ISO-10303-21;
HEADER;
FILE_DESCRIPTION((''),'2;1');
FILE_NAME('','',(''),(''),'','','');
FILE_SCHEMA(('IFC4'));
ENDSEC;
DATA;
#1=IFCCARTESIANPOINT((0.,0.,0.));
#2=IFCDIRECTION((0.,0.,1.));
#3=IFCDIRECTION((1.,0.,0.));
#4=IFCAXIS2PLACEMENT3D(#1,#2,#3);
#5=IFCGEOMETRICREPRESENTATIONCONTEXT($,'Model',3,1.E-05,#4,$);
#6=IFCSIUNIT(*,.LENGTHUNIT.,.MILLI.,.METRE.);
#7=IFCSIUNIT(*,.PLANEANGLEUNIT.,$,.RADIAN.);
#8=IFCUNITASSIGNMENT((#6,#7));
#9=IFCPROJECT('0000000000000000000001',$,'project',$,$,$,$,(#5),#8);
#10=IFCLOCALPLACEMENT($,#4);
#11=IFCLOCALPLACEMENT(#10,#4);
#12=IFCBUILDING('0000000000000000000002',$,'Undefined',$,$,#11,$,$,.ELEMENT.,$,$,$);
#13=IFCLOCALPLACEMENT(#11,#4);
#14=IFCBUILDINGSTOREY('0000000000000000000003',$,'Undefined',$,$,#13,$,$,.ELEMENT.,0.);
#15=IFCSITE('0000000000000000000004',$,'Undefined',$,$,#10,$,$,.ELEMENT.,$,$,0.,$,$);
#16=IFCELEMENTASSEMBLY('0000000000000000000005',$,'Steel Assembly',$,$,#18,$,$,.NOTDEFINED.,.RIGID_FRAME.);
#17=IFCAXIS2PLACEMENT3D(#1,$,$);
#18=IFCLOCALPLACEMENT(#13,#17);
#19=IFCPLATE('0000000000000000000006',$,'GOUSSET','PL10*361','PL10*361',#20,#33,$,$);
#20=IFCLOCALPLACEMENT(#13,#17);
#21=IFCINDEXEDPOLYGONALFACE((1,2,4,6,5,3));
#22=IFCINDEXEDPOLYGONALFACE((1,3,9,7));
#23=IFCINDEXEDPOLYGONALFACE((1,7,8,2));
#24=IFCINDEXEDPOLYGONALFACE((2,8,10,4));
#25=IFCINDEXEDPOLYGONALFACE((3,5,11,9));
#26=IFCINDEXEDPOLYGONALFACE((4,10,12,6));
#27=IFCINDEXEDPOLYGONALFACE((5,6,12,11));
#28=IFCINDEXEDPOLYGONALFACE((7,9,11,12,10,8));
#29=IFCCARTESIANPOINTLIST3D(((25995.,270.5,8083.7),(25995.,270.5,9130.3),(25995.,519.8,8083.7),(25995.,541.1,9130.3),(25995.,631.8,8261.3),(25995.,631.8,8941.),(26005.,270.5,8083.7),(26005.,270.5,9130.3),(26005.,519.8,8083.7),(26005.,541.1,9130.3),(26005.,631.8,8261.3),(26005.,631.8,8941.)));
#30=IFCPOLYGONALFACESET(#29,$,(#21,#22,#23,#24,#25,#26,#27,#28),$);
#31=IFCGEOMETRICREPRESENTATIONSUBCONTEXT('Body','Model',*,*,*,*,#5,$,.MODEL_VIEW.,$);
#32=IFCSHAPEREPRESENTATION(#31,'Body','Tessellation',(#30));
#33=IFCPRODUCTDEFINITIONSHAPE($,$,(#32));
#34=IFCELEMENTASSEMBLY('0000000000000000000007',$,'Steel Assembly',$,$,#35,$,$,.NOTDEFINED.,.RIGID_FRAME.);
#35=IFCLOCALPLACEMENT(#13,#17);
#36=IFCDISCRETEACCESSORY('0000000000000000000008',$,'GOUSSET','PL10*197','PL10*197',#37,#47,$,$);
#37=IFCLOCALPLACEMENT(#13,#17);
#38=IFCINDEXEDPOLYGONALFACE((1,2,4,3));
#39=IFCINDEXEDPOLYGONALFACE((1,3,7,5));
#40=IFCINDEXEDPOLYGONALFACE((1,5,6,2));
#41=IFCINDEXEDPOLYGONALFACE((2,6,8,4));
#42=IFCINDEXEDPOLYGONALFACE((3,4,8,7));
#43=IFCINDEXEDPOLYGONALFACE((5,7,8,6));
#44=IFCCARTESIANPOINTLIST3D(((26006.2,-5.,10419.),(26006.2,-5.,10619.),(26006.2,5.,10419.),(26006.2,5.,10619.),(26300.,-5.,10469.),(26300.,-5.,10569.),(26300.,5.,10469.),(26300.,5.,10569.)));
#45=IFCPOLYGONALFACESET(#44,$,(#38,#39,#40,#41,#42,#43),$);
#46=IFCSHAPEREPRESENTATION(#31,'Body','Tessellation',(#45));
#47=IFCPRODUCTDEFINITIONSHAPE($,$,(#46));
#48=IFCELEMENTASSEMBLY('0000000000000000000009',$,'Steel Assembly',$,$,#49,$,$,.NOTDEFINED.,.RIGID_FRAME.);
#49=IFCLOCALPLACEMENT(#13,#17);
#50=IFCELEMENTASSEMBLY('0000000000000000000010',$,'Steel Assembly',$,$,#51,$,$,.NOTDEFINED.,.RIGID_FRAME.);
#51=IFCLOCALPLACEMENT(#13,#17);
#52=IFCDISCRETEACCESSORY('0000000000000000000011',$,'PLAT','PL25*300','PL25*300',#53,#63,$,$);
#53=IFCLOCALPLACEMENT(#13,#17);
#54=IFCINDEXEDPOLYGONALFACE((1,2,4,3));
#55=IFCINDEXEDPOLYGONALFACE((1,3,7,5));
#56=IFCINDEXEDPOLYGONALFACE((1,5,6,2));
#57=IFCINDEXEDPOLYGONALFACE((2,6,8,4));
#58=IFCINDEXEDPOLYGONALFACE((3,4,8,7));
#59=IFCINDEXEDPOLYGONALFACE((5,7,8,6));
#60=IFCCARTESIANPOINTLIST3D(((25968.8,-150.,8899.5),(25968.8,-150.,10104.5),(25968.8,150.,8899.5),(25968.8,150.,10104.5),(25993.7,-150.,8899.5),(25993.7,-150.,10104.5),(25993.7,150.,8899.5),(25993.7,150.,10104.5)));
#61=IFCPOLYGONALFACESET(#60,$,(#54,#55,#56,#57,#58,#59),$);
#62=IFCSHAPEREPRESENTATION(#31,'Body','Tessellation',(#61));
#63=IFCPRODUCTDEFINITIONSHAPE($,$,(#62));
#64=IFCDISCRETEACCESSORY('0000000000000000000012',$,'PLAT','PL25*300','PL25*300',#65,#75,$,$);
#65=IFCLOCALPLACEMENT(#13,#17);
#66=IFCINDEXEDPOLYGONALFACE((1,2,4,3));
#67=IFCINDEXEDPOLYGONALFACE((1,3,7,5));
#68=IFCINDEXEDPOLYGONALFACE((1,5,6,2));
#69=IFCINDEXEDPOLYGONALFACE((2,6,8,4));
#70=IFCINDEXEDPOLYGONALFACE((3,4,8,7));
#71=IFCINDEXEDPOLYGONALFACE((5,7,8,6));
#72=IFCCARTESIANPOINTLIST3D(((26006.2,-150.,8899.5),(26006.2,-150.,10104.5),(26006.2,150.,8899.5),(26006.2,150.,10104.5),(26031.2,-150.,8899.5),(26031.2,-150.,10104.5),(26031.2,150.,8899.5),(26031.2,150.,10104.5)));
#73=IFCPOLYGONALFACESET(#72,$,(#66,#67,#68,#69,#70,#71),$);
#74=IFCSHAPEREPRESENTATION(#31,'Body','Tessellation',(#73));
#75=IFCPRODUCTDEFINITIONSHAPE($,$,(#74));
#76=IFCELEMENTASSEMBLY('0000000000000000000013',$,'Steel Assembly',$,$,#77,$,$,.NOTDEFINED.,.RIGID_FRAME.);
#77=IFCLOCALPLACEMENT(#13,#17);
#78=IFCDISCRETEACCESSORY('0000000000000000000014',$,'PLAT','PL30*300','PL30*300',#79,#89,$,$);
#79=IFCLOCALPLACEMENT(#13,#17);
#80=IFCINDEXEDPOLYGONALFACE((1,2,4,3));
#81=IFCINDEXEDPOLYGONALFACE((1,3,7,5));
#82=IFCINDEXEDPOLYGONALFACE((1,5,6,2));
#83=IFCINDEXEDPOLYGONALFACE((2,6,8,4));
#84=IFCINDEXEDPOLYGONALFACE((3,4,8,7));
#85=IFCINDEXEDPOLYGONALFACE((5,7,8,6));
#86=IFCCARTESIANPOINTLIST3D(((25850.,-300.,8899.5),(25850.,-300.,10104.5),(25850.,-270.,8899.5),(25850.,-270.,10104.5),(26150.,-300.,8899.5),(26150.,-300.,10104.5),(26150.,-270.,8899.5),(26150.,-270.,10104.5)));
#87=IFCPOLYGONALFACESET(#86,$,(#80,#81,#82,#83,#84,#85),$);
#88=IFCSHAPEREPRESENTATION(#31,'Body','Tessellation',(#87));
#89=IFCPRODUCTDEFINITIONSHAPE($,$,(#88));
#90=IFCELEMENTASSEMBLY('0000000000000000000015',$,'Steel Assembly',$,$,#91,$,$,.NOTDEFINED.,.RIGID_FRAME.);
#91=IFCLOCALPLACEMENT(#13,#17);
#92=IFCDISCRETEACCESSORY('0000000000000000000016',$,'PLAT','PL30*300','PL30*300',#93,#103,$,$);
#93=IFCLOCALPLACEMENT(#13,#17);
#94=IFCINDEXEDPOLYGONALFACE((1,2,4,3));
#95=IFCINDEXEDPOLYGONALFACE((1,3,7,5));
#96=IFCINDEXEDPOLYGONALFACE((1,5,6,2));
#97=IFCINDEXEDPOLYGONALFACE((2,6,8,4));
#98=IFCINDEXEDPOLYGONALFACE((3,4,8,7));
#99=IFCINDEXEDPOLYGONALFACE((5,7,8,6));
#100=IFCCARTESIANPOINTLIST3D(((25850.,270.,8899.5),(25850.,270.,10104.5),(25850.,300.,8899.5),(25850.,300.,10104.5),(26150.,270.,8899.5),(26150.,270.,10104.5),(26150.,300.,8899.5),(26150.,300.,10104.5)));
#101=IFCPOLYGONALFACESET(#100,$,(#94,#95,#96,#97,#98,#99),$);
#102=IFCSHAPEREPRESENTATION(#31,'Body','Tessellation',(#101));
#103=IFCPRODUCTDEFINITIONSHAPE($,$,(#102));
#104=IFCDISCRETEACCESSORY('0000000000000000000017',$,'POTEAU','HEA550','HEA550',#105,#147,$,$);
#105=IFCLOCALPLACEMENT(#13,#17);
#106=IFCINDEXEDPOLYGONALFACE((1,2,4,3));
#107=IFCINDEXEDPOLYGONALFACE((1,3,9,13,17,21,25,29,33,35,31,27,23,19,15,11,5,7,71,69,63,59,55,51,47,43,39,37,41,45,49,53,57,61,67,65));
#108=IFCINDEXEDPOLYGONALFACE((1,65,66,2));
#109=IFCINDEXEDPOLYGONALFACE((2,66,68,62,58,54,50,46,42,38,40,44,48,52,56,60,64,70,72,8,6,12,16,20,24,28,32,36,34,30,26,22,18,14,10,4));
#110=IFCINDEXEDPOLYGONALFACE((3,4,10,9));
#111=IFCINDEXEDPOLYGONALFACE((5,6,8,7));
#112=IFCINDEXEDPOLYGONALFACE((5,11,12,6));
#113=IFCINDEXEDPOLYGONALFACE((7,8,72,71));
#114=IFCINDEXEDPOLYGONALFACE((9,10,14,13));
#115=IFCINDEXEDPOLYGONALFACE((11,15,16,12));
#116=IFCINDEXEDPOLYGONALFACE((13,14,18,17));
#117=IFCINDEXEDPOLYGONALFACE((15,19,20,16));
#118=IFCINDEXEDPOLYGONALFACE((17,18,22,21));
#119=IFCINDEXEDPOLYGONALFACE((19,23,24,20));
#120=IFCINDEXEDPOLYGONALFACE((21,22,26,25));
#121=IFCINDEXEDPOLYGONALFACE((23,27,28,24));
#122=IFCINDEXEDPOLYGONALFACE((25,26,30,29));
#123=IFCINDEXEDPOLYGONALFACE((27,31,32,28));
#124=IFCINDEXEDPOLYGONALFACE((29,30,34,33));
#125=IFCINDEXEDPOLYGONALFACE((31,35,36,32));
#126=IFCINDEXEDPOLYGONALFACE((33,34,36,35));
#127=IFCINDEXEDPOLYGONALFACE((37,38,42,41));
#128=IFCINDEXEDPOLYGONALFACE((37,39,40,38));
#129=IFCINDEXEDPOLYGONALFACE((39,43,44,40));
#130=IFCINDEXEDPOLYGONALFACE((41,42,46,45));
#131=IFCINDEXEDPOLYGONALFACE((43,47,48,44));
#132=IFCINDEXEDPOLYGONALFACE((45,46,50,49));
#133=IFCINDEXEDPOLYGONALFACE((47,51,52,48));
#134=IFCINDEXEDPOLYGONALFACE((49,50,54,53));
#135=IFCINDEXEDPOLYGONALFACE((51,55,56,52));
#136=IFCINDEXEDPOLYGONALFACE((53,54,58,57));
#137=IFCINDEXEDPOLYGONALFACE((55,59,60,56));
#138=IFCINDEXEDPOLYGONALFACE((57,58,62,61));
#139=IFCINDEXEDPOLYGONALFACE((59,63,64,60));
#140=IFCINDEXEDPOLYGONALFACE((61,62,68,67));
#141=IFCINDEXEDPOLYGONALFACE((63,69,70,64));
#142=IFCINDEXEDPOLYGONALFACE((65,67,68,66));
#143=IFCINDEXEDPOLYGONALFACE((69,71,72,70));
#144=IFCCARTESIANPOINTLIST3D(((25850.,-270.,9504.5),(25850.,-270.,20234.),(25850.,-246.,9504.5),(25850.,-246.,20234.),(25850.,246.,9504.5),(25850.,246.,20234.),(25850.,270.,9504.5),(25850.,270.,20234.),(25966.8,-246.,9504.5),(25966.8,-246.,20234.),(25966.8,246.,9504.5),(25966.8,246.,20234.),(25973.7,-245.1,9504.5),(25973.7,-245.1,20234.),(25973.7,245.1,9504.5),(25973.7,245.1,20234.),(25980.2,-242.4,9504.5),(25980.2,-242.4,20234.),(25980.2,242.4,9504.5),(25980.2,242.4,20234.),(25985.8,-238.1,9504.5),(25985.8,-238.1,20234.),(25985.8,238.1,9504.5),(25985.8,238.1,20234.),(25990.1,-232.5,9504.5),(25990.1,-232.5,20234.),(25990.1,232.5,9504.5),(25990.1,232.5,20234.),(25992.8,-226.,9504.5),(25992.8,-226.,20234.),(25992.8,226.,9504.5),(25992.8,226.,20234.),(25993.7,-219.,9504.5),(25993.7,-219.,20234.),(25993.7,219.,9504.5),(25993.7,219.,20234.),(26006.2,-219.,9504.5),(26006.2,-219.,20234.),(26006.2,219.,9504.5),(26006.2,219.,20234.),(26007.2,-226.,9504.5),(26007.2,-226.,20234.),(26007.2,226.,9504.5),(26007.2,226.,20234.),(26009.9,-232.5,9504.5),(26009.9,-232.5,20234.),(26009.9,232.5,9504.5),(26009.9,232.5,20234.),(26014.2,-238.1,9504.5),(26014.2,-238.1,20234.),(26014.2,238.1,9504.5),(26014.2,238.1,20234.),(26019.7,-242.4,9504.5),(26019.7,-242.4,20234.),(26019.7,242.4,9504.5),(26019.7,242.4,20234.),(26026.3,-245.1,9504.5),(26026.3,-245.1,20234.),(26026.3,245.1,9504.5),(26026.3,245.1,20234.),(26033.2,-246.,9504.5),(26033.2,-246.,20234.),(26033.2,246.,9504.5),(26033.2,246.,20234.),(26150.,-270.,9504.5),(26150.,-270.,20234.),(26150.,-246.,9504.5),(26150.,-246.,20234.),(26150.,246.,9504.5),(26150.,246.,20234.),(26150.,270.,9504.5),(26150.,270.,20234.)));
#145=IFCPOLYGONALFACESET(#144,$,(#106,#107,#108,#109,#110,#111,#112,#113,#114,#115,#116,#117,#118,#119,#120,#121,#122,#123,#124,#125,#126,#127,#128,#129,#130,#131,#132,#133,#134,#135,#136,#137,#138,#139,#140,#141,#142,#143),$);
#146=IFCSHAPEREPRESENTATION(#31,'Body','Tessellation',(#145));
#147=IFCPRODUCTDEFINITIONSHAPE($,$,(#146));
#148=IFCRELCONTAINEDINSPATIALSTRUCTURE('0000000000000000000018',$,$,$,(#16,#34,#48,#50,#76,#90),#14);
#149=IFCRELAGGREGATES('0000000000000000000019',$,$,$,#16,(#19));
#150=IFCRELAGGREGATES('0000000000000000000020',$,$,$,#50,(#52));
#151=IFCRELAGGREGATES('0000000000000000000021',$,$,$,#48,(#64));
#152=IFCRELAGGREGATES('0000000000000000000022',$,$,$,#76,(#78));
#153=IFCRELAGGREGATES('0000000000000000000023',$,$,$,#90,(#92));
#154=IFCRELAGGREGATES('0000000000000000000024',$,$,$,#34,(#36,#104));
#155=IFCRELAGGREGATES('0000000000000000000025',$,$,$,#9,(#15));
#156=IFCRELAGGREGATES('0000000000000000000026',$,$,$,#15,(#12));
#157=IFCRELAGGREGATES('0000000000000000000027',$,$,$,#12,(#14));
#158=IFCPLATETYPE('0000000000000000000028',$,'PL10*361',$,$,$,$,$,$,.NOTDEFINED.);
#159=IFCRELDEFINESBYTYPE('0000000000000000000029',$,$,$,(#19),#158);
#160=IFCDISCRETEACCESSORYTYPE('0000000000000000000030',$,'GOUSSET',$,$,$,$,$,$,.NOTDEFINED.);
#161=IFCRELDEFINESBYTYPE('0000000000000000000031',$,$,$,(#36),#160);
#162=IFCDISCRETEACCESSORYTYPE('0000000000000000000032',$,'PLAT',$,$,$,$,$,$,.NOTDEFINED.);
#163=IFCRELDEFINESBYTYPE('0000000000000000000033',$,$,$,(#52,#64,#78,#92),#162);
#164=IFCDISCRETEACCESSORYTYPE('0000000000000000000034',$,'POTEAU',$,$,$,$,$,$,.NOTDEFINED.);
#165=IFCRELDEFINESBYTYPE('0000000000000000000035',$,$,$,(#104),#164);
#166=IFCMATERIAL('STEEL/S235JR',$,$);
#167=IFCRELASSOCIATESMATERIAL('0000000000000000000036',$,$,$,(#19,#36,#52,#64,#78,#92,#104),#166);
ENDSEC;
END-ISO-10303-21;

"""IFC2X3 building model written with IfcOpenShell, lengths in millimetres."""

from ifc_helpers import new_model, si_unit, frame, origin_with_axes, origin_2d_with_axis, place, context, subcontext, project, spatial, polyline, i_section, outline, extrude, material, type_object, element, aggregate, save


model = new_model("IFC2X3")

# Units and contexts
model_context = context("Model", 3, precision=1e-05, world=origin_with_axes())
body_context = subcontext(model_context, "Body", "Model", "MODEL_VIEW")
ifc_project = project(units=[si_unit("LENGTHUNIT", "METRE", prefix="MILLI"), si_unit("PLANEANGLEUNIT", "RADIAN")], contexts=[model_context])

# Site, building, storey
site_placement = place(None, origin_with_axes())
site = spatial("IfcSite", under=ifc_project, at=site_placement, Name="Undefined", CompositionType="ELEMENT", RefElevation=0.0)
building_placement = place(site_placement, origin_with_axes())
building = spatial("IfcBuilding", under=site, at=building_placement, Name="Undefined", CompositionType="ELEMENT")
storey_placement = place(building_placement, origin_with_axes())
storey = spatial("IfcBuildingStorey", under=building, at=storey_placement, Name="Undefined", CompositionType="ELEMENT", Elevation=0.0)

# Shared definitions
ifc_material_1 = material(Name="STEEL/S235JR")

# Element assembly, plate
plate_type = type_object("IfcPlateType", Name="PL10*361", PredefinedType="NOTDEFINED")
assembly_1_placement = place(storey_placement, origin_with_axes())
assembly_1 = element("IfcElementAssembly", 1, at=assembly_1_placement, inside=storey, Name="Steel Assembly", AssemblyPlace="NOTDEFINED", PredefinedType="RIGID_FRAME")
plate_1_placement = place(assembly_1_placement, frame((26000.0, 541.1, 9130.3), z_axis=(1.0, 0.0, 0.0), x_axis=(0.0, -1.0, 0.0)))
plate_1 = element("IfcPlate", 2, at=plate_1_placement, type_object=plate_type, material=ifc_material_1, Name="GOUSSET", Description="PL10*361", ObjectType="PL10*361", context=body_context, shape_type="SweptSolid", body=[
    extrude(outline(polyline([(0.0, 0.0), (270.5, 0.0), (270.5, 1046.7), (21.3, 1046.7), (-90.7, 869.1), (-90.7, 189.4), (0.0, 0.0)])), frame((0.0, 0.0, -5.0), z_axis=(0.0, 0.0, 1.0), x_axis=(1.0, 0.0, 0.0)), (0.0, 0.0, 1.0), 10.0),
])
aggregate(assembly_1, [plate_1])

# Element assembly, discrete accessory
assembly_2_placement = place(storey_placement, origin_with_axes())
assembly_2 = element("IfcElementAssembly", 3, at=assembly_2_placement, inside=storey, Name="Steel Assembly", AssemblyPlace="NOTDEFINED", PredefinedType="RIGID_FRAME")
discrete_accessory_type_1 = type_object("IfcDiscreteAccessoryType", Name="GOUSSET")
discrete_accessory_1_placement = place(assembly_2_placement, frame((26006.2, 0.0, 10619.0), z_axis=(0.0, -1.0, 0.0), x_axis=(0.0, 0.0, -1.0)))
discrete_accessory_1 = element("IfcDiscreteAccessory", 4, at=discrete_accessory_1_placement, type_object=discrete_accessory_type_1, material=ifc_material_1, Name="GOUSSET", Description="PL10*197", ObjectType="PL10*197", context=body_context, shape_type="SweptSolid", body=[
    extrude(outline(polyline([(0.0, 0.0), (200.0, 0.0), (150.0, 293.8), (50.0, 293.8), (0.0, 0.0)])), frame((0.0, 0.0, -5.0), z_axis=(0.0, 0.0, 1.0), x_axis=(1.0, 0.0, 0.0)), (0.0, 0.0, 1.0), 10.0),
])

# Element assembly
assembly_3_placement = place(storey_placement, origin_with_axes())
assembly_3 = element("IfcElementAssembly", 5, at=assembly_3_placement, inside=storey, Name="Steel Assembly", AssemblyPlace="NOTDEFINED", PredefinedType="RIGID_FRAME")

# Element assembly, discrete accessory
assembly_4_placement = place(storey_placement, origin_with_axes())
assembly_4 = element("IfcElementAssembly", 6, at=assembly_4_placement, inside=storey, Name="Steel Assembly", AssemblyPlace="NOTDEFINED", PredefinedType="RIGID_FRAME")
discrete_accessory_type_2 = type_object("IfcDiscreteAccessoryType", Name="PLAT")
discrete_accessory_2_placement = place(assembly_4_placement, frame((25981.2, 0.0, 10104.5), z_axis=(1.0, 0.0, 0.0), x_axis=(0.0, 0.0, -1.0)))
discrete_accessory_2 = element("IfcDiscreteAccessory", 7, at=discrete_accessory_2_placement, type_object=discrete_accessory_type_2, material=ifc_material_1, Name="PLAT", Description="PL25*300", ObjectType="PL25*300", context=body_context, shape_type="SweptSolid", body=[
    extrude(outline(polyline([(0.0, -150.0), (0.0, 150.0), (1205.0, 150.0), (1205.0, -150.0), (0.0, -150.0)])), frame((0.0, 0.0, -12.5), z_axis=(0.0, 0.0, 1.0), x_axis=(1.0, 0.0, 0.0)), (0.0, 0.0, 1.0), 25.0),
])
aggregate(assembly_4, [discrete_accessory_2])

# Discrete accessory
discrete_accessory_3_placement = place(assembly_3_placement, frame((26018.8, 0.0, 10104.5), z_axis=(1.0, 0.0, 0.0), x_axis=(0.0, 0.0, -1.0)))
discrete_accessory_3 = element("IfcDiscreteAccessory", 8, at=discrete_accessory_3_placement, type_object=discrete_accessory_type_2, material=ifc_material_1, Name="PLAT", Description="PL25*300", ObjectType="PL25*300", context=body_context, shape_type="SweptSolid", body=[
    extrude(outline(polyline([(0.0, -150.0), (0.0, 150.0), (1205.0, 150.0), (1205.0, -150.0), (0.0, -150.0)])), frame((0.0, 0.0, -12.5), z_axis=(0.0, 0.0, 1.0), x_axis=(1.0, 0.0, 0.0)), (0.0, 0.0, 1.0), 25.0),
])
aggregate(assembly_3, [discrete_accessory_3])

# Element assemblies, discrete accessories
assembly_5_placement = place(storey_placement, origin_with_axes())
assembly_5 = element("IfcElementAssembly", 9, at=assembly_5_placement, inside=storey, Name="Steel Assembly", AssemblyPlace="NOTDEFINED", PredefinedType="RIGID_FRAME")
discrete_accessory_4_placement = place(assembly_5_placement, frame((26000.0, -285.0, 10104.5), z_axis=(0.0, -1.0, 0.0), x_axis=(0.0, 0.0, -1.0)))
discrete_accessory_4 = element("IfcDiscreteAccessory", 10, at=discrete_accessory_4_placement, type_object=discrete_accessory_type_2, material=ifc_material_1, Name="PLAT", Description="PL30*300", ObjectType="PL30*300", context=body_context, shape_type="SweptSolid", body=[
    extrude(outline(polyline([(0.0, -150.0), (0.0, 150.0), (1205.0, 150.0), (1205.0, -150.0), (0.0, -150.0)])), frame((0.0, 0.0, -15.0), z_axis=(0.0, 0.0, 1.0), x_axis=(1.0, 0.0, 0.0)), (0.0, 0.0, 1.0), 30.0),
])
aggregate(assembly_5, [discrete_accessory_4])
assembly_6_placement = place(storey_placement, origin_with_axes())
assembly_6 = element("IfcElementAssembly", 11, at=assembly_6_placement, inside=storey, Name="Steel Assembly", AssemblyPlace="NOTDEFINED", PredefinedType="RIGID_FRAME")
discrete_accessory_5_placement = place(assembly_6_placement, frame((26000.0, 285.0, 10104.5), z_axis=(0.0, -1.0, 0.0), x_axis=(0.0, 0.0, -1.0)))
discrete_accessory_5 = element("IfcDiscreteAccessory", 12, at=discrete_accessory_5_placement, type_object=discrete_accessory_type_2, material=ifc_material_1, Name="PLAT", Description="PL30*300", ObjectType="PL30*300", context=body_context, shape_type="SweptSolid", body=[
    extrude(outline(polyline([(0.0, -150.0), (0.0, 150.0), (1205.0, 150.0), (1205.0, -150.0), (0.0, -150.0)])), frame((0.0, 0.0, -15.0), z_axis=(0.0, 0.0, 1.0), x_axis=(1.0, 0.0, 0.0)), (0.0, 0.0, 1.0), 30.0),
])
aggregate(assembly_6, [discrete_accessory_5])

# Discrete accessory
discrete_accessory_type_3 = type_object("IfcDiscreteAccessoryType", Name="POTEAU")
discrete_accessory_6_placement = place(assembly_2_placement, frame((26000.0, 0.0, 9502.0), z_axis=(0.0, 0.0, 1.0), x_axis=(1.0, 0.0, 0.0)))
discrete_accessory_6 = element("IfcDiscreteAccessory", 13, at=discrete_accessory_6_placement, type_object=discrete_accessory_type_3, material=ifc_material_1, Name="POTEAU", Description="HEA550", ObjectType="HEA550", context=body_context, shape_type="SweptSolid", body=[
    extrude(i_section(OverallWidth=300.0, OverallDepth=540.0, WebThickness=12.5, FlangeThickness=24.0, FilletRadius=27.0, at=origin_2d_with_axis()), frame((0.0, 0.0, 10732.0), z_axis=(0.0, 0.0, -1.0), x_axis=(-1.0, 0.0, 0.0)), (0.0, 0.0, 1.0), 10729.5),
])
aggregate(assembly_2, [discrete_accessory_1, discrete_accessory_6])

save(model, "model.ifc")
